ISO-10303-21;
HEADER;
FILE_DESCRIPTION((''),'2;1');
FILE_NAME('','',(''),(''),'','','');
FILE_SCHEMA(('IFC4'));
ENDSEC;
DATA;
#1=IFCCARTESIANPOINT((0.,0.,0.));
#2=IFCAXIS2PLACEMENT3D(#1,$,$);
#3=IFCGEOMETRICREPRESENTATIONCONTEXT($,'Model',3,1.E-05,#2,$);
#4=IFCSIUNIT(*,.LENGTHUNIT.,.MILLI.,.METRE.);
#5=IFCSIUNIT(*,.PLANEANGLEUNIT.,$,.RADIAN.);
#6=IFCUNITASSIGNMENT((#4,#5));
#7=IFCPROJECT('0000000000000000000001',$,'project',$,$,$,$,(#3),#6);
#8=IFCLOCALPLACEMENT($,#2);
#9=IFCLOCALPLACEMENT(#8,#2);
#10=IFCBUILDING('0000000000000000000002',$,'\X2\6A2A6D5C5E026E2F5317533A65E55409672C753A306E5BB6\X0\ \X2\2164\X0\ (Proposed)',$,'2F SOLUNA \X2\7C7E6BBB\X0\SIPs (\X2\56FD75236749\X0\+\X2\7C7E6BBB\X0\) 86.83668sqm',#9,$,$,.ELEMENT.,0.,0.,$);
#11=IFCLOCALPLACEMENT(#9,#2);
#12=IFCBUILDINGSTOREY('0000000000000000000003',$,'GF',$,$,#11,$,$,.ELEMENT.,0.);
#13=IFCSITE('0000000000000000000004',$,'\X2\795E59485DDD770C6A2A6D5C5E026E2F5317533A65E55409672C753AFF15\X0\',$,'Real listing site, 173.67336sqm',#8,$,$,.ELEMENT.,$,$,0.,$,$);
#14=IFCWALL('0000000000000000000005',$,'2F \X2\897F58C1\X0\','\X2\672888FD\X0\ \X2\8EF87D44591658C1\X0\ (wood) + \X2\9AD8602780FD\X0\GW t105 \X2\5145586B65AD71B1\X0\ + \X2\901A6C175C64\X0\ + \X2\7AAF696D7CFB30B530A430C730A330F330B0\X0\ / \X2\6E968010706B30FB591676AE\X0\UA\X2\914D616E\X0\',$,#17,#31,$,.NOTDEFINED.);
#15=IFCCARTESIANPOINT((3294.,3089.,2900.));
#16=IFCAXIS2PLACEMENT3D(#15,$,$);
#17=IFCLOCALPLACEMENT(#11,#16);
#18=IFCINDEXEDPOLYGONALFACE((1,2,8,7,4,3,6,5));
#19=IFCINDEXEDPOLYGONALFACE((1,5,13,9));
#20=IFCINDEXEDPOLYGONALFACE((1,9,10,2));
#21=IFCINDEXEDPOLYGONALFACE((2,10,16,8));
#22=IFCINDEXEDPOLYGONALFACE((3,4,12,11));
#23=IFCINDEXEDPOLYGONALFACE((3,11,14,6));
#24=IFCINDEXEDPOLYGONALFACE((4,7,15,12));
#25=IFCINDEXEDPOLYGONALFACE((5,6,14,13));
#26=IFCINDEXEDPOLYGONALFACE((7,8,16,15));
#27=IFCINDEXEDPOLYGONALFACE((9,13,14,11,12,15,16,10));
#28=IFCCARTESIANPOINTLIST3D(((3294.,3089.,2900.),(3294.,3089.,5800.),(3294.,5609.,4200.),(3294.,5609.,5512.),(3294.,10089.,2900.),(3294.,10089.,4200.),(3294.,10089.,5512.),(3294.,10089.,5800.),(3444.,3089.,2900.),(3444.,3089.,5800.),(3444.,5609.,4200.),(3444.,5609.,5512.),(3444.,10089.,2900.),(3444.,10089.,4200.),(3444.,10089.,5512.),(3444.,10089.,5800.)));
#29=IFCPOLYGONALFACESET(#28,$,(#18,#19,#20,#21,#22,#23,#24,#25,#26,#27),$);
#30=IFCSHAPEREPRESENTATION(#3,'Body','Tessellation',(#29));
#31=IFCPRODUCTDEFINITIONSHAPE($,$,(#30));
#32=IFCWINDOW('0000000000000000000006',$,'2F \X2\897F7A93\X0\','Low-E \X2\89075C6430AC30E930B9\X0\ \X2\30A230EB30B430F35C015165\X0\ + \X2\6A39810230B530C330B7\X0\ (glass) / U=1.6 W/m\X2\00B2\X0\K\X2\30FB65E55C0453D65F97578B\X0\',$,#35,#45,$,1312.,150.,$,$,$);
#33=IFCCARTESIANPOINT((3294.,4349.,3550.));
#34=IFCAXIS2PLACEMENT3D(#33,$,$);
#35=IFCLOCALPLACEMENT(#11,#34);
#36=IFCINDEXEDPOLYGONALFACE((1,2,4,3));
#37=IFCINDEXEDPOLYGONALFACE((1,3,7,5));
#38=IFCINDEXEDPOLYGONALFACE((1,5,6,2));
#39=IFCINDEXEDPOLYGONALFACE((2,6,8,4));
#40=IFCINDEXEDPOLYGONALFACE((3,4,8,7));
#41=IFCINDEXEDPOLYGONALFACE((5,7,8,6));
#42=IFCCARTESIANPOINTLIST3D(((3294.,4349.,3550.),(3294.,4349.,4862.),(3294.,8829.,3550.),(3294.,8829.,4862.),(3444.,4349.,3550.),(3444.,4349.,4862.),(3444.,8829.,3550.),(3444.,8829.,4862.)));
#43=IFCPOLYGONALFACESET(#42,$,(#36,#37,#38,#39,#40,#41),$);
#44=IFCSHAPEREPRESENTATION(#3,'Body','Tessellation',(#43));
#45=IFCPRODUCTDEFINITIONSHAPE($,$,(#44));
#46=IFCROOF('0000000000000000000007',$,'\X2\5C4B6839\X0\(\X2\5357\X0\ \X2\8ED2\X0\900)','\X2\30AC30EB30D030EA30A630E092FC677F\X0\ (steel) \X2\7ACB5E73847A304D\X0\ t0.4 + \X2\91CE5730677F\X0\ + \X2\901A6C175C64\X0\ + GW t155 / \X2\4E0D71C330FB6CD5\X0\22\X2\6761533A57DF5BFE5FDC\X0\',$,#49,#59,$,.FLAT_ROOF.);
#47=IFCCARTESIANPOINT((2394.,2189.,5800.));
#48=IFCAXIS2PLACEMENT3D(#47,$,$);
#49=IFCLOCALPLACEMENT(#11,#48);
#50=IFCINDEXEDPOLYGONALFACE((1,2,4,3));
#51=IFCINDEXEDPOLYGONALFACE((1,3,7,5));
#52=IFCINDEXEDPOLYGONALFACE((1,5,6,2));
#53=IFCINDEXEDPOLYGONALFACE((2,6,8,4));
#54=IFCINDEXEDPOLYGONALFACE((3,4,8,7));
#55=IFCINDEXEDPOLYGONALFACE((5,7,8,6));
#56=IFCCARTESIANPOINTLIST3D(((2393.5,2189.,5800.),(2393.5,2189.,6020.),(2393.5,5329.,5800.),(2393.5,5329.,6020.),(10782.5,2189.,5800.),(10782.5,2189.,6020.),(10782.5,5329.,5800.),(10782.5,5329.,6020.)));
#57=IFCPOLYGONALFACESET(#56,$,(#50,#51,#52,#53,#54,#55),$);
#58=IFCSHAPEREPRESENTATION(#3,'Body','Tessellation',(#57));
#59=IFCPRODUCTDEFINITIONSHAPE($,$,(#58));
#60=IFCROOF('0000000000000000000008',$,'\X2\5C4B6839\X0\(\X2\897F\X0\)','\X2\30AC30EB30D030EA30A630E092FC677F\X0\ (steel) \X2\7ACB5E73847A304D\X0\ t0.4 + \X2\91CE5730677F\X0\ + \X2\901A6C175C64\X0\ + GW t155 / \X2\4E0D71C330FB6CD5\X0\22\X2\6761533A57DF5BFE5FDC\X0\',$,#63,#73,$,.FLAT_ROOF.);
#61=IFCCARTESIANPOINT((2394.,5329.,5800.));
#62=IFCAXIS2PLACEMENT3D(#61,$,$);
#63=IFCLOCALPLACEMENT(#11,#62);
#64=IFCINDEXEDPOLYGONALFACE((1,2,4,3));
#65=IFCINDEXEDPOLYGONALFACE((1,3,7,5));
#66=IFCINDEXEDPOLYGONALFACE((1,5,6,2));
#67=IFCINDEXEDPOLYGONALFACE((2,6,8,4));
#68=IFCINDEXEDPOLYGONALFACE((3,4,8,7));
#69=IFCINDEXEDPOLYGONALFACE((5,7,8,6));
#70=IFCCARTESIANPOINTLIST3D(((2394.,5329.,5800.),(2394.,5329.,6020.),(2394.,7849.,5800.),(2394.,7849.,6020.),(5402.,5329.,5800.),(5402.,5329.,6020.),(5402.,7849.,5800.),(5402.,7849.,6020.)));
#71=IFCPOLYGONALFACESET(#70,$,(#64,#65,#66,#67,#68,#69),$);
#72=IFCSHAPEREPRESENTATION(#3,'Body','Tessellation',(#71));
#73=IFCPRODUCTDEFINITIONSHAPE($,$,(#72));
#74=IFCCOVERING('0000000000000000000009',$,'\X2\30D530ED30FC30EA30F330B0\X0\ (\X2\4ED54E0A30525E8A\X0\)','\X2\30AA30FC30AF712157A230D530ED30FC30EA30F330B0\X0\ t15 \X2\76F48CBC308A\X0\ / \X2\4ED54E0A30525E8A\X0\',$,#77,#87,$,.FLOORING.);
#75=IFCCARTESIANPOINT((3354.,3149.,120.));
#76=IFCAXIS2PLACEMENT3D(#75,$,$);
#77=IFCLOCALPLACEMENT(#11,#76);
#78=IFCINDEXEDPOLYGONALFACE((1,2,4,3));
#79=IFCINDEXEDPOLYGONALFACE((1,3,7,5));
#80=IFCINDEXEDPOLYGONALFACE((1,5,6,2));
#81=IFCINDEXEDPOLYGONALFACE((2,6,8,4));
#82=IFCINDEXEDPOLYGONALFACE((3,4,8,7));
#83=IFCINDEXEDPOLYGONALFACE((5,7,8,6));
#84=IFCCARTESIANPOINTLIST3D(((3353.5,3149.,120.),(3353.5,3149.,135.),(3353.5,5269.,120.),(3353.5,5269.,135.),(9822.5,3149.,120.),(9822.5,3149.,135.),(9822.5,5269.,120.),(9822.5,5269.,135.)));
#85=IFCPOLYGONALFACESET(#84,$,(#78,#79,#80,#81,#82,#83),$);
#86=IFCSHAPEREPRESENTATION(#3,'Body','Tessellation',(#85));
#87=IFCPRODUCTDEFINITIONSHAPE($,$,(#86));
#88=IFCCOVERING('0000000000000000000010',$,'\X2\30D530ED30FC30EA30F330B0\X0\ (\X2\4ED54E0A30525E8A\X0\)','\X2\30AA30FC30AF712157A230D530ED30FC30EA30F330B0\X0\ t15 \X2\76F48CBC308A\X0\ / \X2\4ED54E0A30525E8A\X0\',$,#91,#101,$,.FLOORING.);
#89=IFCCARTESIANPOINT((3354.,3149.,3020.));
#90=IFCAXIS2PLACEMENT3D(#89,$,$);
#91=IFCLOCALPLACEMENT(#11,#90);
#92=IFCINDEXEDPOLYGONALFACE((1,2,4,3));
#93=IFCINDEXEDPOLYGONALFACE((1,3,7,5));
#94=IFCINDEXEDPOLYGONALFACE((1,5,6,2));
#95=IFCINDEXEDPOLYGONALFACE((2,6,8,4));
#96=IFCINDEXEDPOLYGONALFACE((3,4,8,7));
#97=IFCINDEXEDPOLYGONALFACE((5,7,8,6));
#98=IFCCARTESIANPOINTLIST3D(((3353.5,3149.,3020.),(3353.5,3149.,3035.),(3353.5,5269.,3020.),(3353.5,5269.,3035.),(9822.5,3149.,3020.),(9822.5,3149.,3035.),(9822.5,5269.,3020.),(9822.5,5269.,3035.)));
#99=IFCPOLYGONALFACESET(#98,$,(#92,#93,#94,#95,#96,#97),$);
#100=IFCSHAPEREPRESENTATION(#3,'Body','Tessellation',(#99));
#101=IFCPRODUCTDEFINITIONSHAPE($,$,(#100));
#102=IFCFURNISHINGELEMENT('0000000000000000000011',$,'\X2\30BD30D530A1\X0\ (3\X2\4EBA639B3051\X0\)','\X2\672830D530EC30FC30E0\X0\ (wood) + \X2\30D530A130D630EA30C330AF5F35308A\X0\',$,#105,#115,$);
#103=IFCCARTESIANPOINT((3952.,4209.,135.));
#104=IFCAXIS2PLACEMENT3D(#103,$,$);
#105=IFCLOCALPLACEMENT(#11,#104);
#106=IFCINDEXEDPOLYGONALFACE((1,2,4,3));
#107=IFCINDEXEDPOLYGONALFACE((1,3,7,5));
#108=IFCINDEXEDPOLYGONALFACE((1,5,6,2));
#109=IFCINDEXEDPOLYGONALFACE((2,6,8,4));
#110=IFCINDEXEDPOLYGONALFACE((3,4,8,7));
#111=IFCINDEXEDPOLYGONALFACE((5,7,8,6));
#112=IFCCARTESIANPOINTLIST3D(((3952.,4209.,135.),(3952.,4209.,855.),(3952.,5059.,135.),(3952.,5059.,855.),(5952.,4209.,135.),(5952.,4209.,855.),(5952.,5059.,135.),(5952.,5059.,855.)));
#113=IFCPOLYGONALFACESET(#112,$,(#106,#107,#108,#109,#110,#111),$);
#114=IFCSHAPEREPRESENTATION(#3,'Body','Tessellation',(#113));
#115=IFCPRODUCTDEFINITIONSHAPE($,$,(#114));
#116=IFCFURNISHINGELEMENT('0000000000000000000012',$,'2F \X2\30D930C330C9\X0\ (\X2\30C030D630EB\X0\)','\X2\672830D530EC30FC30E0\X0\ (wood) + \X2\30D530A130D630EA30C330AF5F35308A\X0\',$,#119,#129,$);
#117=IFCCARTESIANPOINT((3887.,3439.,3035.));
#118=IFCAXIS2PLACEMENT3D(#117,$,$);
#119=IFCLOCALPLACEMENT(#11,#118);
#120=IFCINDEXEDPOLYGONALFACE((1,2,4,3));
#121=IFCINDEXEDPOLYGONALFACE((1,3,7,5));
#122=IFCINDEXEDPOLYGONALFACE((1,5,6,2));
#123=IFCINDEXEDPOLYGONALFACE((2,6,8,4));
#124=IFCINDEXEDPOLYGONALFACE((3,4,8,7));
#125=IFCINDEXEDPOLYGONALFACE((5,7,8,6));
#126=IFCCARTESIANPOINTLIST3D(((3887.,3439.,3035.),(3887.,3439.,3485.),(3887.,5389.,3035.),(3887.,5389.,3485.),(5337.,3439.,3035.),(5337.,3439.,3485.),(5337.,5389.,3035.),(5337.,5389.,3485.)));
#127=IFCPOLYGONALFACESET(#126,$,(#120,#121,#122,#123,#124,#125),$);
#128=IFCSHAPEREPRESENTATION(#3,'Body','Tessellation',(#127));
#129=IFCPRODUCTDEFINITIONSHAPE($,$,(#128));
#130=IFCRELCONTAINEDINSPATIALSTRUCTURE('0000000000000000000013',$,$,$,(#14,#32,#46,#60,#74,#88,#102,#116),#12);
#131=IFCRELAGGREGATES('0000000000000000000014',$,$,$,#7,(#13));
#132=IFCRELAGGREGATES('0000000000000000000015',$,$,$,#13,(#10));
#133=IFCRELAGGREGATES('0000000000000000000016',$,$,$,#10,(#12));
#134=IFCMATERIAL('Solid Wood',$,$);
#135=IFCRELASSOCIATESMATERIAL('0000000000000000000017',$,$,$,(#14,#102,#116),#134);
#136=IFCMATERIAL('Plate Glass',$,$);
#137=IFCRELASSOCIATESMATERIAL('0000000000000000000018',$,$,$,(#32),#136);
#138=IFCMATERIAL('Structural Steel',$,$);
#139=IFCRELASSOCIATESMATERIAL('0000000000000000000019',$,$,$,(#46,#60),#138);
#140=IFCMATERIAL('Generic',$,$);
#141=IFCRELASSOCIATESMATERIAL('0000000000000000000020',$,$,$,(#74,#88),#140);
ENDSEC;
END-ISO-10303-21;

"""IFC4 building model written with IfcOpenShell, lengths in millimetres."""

from ifc_helpers import new_model, si_unit, frame, frame_2d, origin, place, context, project, spatial, rectangle, extrude, material, element, fill, save


model = new_model("IFC4")

# Units and contexts
model_context = context("Model", 3, precision=1e-05, world=origin())
ifc_project = project(units=[si_unit("LENGTHUNIT", "METRE", prefix="MILLI"), si_unit("PLANEANGLEUNIT", "RADIAN")], contexts=[model_context])

# Site, building, storey
site_placement = place(None, origin())
site = spatial("IfcSite", under=ifc_project, at=site_placement, Name="神奈川県横浜市港北区日吉本町５", ObjectType="Real listing site, 173.67336sqm", CompositionType="ELEMENT", RefElevation=0.0)
building_placement = place(site_placement, origin())
building = spatial("IfcBuilding", under=site, at=building_placement, Name="横浜市港北区日吉本町の家 Ⅴ (Proposed)", ObjectType="2F SOLUNA 籾殻SIPs (国産杉+籾殻) 86.83668sqm", CompositionType="ELEMENT", ElevationOfRefHeight=0.0, ElevationOfTerrain=0.0)
storey_placement = place(building_placement, origin())
storey = spatial("IfcBuildingStorey", under=building, at=storey_placement, Name="GF", CompositionType="ELEMENT", Elevation=0.0)

# Shared definitions
ifc_material_1 = material(Name="Solid Wood")

# Shared definitions
ifc_material_2 = material(Name="Plate Glass")

# Wall, opening, window
wall_1_placement = place(storey_placement, frame((3294.0, 3089.0, 2900.0)))
wall_1 = element("IfcWall", 1, at=wall_1_placement, inside=storey, material=ifc_material_1, Name="2F 西壁", Description="木製 軸組外壁 (wood) + 高性能GW t105 充填断熱 + 通気層 + 窯業系サイディング / 準耐火・外皮UA配慮", PredefinedType="NOTDEFINED", context=model_context, shape_type="SweptSolid", body=[
    extrude(rectangle(XDim=150.0, YDim=7000.0, at=frame_2d((75.0, 3500.0))), frame((3294.0, 3089.0, 2900.0)), (0.0, 0.0, 1.0), 2900.0),
])
opening_1_placement = place(storey_placement, frame((3294.0, 4349.0, 3550.0)))
opening_1 = element("IfcOpeningElement", 2, at=opening_1_placement, cuts=wall_1, PredefinedType="NOTDEFINED", context=model_context, shape_type="SweptSolid", body=[
    extrude(rectangle(XDim=150.0, YDim=4480.0, at=frame_2d((75.0, 2240.0))), frame((3294.0, 4349.0, 3550.0)), (0.0, 0.0, 1.0), 1312.0),
])
window_1_placement = place(storey_placement, frame((3294.0, 4349.0, 3550.0)))
window_1 = element("IfcWindow", 3, at=window_1_placement, inside=storey, material=ifc_material_2, Name="2F 西窓", Description="Low-E 複層ガラス アルゴン封入 + 樹脂サッシ (glass) / U=1.6 W/m²K・日射取得型", OverallHeight=1312.0, OverallWidth=150.0, context=model_context, shape_type="SweptSolid", body=[
    extrude(rectangle(XDim=150.0, YDim=4480.0, at=frame_2d((75.0, 2240.0))), frame((3294.0, 4349.0, 3550.0)), (0.0, 0.0, 1.0), 1312.0),
])
fill(opening_1, window_1)

# Roofs
ifc_material_3 = material(Name="Structural Steel")
roof_1_placement = place(storey_placement, frame((2394.0, 2189.0, 5800.0)))
element("IfcRoof", 4, at=roof_1_placement, inside=storey, material=ifc_material_3, Name="屋根(南 軒900)", Description="ガルバリウム鋼板 (steel) 立平葺き t0.4 + 野地板 + 通気層 + GW t155 / 不燃・法22条区域対応", PredefinedType="FLAT_ROOF", context=model_context, shape_type="SweptSolid", body=[
    extrude(rectangle(XDim=8389.0, YDim=3140.0, at=frame_2d((4194.0, 1570.0))), frame((2394.0, 2189.0, 5800.0)), (0.0, 0.0, 1.0), 220.0),
])
roof_2_placement = place(storey_placement, frame((2394.0, 5329.0, 5800.0)))
element("IfcRoof", 5, at=roof_2_placement, inside=storey, material=ifc_material_3, Name="屋根(西)", Description="ガルバリウム鋼板 (steel) 立平葺き t0.4 + 野地板 + 通気層 + GW t155 / 不燃・法22条区域対応", PredefinedType="FLAT_ROOF", context=model_context, shape_type="SweptSolid", body=[
    extrude(rectangle(XDim=3008.0, YDim=2520.0, at=frame_2d((1504.0, 1260.0))), frame((2394.0, 5329.0, 5800.0)), (0.0, 0.0, 1.0), 220.0),
])

# Coverings
ifc_material_4 = material(Name="Generic")
covering_1_placement = place(storey_placement, frame((3354.0, 3149.0, 120.0)))
element("IfcCovering", 6, at=covering_1_placement, inside=storey, material=ifc_material_4, Name="フローリング (仕上げ床)", Description="オーク無垢フローリング t15 直貼り / 仕上げ床", PredefinedType="FLOORING", context=model_context, shape_type="SweptSolid", body=[
    extrude(rectangle(XDim=6469.0, YDim=2120.0, at=frame_2d((3234.0, 1060.0))), frame((3354.0, 3149.0, 120.0)), (0.0, 0.0, 1.0), 15.0),
])
covering_2_placement = place(storey_placement, frame((3354.0, 3149.0, 3020.0)))
element("IfcCovering", 7, at=covering_2_placement, inside=storey, material=ifc_material_4, Name="フローリング (仕上げ床)", Description="オーク無垢フローリング t15 直貼り / 仕上げ床", PredefinedType="FLOORING", context=model_context, shape_type="SweptSolid", body=[
    extrude(rectangle(XDim=6469.0, YDim=2120.0, at=frame_2d((3234.0, 1060.0))), frame((3354.0, 3149.0, 3020.0)), (0.0, 0.0, 1.0), 15.0),
])

# Furnishing elements
furnishing_1_placement = place(storey_placement, frame((3952.0, 4209.0, 135.0)))
element("IfcFurnishingElement", 8, at=furnishing_1_placement, inside=storey, material=ifc_material_1, Name="ソファ (3人掛け)", Description="木フレーム (wood) + ファブリック張り", context=model_context, shape_type="SweptSolid", body=[
    extrude(rectangle(XDim=2000.0, YDim=850.0, at=frame_2d((1000.0, 425.0))), frame((3952.0, 4209.0, 135.0)), (0.0, 0.0, 1.0), 720.0),
])
furnishing_2_placement = place(storey_placement, frame((3887.0, 3439.0, 3035.0)))
element("IfcFurnishingElement", 9, at=furnishing_2_placement, inside=storey, material=ifc_material_1, Name="2F ベッド (ダブル)", Description="木フレーム (wood) + ファブリック張り", context=model_context, shape_type="SweptSolid", body=[
    extrude(rectangle(XDim=1450.0, YDim=1950.0, at=frame_2d((725.0, 975.0))), frame((3887.0, 3439.0, 3035.0)), (0.0, 0.0, 1.0), 450.0),
])

save(model, "model.ifc")
